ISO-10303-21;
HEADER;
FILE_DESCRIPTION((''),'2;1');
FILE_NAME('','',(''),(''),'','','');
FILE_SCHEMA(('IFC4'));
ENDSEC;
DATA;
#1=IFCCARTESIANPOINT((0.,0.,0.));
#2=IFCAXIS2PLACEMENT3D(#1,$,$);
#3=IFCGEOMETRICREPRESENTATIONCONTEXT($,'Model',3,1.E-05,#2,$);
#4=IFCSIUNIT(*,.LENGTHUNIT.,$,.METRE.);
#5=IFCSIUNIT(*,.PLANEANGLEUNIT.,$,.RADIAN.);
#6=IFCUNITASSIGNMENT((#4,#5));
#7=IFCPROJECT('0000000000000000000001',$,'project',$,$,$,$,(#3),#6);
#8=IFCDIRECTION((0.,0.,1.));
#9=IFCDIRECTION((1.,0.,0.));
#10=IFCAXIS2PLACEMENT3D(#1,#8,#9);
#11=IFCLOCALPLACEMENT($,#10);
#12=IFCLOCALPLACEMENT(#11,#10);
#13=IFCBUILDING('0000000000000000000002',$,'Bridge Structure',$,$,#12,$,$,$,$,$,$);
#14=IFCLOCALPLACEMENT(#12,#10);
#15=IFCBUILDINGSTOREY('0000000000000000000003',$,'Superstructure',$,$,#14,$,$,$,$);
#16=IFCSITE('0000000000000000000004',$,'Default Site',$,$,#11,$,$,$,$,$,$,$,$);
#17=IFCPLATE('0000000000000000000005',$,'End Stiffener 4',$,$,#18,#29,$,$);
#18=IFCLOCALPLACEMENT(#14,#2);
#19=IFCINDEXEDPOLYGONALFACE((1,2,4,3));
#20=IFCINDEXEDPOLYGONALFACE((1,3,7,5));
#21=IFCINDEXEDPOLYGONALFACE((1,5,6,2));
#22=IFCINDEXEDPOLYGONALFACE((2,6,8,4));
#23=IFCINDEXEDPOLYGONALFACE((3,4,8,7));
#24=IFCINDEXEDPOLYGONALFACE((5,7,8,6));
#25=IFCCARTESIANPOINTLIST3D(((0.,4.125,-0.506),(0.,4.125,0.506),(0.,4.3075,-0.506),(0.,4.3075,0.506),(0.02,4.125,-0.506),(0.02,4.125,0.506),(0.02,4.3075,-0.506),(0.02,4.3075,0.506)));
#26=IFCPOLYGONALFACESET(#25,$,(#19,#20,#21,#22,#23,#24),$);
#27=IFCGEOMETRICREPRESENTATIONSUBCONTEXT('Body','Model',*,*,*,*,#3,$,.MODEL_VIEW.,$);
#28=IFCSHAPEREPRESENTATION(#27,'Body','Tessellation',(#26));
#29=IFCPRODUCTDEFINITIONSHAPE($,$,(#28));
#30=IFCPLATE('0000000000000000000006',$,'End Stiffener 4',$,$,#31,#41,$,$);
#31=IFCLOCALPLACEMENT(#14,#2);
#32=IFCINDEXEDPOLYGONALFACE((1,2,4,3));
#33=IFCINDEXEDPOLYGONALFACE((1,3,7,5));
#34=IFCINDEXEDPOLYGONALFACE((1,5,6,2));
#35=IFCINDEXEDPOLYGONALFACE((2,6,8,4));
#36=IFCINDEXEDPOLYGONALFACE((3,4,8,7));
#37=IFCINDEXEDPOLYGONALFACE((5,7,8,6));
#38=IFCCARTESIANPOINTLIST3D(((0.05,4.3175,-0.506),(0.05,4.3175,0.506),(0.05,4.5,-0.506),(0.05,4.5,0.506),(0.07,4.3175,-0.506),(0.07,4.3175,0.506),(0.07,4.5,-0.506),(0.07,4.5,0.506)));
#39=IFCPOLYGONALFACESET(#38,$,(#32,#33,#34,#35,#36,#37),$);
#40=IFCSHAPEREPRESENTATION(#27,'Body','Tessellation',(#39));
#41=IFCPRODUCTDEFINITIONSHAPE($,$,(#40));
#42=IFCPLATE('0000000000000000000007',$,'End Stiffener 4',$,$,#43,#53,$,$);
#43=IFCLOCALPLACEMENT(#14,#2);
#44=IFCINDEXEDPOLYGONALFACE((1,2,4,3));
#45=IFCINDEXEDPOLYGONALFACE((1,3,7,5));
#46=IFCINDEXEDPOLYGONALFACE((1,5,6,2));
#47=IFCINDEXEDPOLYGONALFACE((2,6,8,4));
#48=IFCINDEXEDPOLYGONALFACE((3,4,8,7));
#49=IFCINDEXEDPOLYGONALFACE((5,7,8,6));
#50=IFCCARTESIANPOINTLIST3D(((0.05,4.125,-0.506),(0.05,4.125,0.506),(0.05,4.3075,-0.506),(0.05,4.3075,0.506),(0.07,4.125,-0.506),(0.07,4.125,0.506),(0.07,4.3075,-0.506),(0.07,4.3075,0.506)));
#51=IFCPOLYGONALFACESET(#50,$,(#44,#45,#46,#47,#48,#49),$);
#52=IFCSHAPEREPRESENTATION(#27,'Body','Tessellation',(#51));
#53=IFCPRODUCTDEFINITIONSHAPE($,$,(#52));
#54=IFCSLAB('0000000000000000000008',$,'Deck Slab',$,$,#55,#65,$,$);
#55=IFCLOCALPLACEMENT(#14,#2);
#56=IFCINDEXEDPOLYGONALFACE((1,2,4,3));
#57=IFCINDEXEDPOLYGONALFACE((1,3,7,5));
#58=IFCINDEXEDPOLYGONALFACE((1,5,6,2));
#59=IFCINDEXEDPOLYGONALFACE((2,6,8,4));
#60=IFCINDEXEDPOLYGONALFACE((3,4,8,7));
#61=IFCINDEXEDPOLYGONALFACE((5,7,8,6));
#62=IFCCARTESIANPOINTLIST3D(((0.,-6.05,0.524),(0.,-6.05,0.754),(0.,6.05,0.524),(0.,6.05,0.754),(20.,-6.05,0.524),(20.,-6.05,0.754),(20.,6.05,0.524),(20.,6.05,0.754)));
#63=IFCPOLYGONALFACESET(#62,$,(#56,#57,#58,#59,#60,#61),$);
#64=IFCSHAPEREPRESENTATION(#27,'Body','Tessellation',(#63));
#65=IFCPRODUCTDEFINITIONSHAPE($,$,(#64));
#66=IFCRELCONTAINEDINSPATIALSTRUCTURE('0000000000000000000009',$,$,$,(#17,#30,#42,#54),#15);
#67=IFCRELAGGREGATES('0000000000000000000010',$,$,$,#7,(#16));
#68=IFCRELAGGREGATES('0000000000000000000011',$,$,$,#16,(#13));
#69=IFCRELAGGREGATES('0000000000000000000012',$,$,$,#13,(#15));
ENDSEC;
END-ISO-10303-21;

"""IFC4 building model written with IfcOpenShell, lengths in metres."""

from ifc_helpers import new_model, si_unit, frame, origin, origin_with_axes, origin_2d_with_axis, place, context, subcontext, project, spatial, polyline, rectangle, outline, extrude, element, save


model = new_model("IFC4")

# Units and contexts
model_context = context("Model", 3, precision=1e-05, world=origin())
body_context = subcontext(model_context, "Body", "Model", "MODEL_VIEW")
ifc_project = project(units=[si_unit("LENGTHUNIT", "METRE"), si_unit("PLANEANGLEUNIT", "RADIAN")], contexts=[model_context])

# Site, building, storey
site_placement = place(None, origin_with_axes())
site = spatial("IfcSite", under=ifc_project, at=site_placement, Name="Default Site")
building_placement = place(site_placement, origin_with_axes())
building = spatial("IfcBuilding", under=site, at=building_placement, Name="Bridge Structure")
storey_placement = place(building_placement, origin_with_axes())
storey = spatial("IfcBuildingStorey", under=building, at=storey_placement, Name="Superstructure")

# Plates
for number, where, z_axis, x_axis, name in (
    (1, (0.01, 4.2163, -0.506), (0.0, 0.0, 1.0), (1.0, 0.0, 0.0), "End Stiffener 4"),
    (2, (0.06, 4.4088, -0.506), (0.0, 0.0, 1.0), (1.0, 0.0, 0.0), "End Stiffener 4"),
    (3, (0.06, 4.2163, -0.506), (0.0, 0.0, 1.0), (1.0, 0.0, 0.0), "End Stiffener 4"),
):
    element("IfcPlate", number, at=place(storey_placement, frame(where, z_axis=z_axis, x_axis=x_axis)), inside=storey, Name=name, context=body_context, shape_type="SweptSolid", body=[
        extrude(rectangle(XDim=0.02, YDim=0.1825, at=origin_2d_with_axis()), origin_with_axes(), (0.0, 0.0, 1.0), 1.012),
    ])

# Slab
slab_placement = place(storey_placement, frame((0.0, 0.0, 0.524), z_axis=(0.0, 0.0, 1.0), x_axis=(1.0, 0.0, 0.0)))
element("IfcSlab", 4, at=slab_placement, inside=storey, Name="Deck Slab", context=body_context, shape_type="SweptSolid", body=[
    extrude(outline(polyline([(0.0, -6.05), (20.0, -6.05), (20.0, 6.05), (0.0, 6.05), (0.0, -6.05)])), origin_with_axes(), (0.0, 0.0, 1.0), 0.23),
])

save(model, "model.ifc")
